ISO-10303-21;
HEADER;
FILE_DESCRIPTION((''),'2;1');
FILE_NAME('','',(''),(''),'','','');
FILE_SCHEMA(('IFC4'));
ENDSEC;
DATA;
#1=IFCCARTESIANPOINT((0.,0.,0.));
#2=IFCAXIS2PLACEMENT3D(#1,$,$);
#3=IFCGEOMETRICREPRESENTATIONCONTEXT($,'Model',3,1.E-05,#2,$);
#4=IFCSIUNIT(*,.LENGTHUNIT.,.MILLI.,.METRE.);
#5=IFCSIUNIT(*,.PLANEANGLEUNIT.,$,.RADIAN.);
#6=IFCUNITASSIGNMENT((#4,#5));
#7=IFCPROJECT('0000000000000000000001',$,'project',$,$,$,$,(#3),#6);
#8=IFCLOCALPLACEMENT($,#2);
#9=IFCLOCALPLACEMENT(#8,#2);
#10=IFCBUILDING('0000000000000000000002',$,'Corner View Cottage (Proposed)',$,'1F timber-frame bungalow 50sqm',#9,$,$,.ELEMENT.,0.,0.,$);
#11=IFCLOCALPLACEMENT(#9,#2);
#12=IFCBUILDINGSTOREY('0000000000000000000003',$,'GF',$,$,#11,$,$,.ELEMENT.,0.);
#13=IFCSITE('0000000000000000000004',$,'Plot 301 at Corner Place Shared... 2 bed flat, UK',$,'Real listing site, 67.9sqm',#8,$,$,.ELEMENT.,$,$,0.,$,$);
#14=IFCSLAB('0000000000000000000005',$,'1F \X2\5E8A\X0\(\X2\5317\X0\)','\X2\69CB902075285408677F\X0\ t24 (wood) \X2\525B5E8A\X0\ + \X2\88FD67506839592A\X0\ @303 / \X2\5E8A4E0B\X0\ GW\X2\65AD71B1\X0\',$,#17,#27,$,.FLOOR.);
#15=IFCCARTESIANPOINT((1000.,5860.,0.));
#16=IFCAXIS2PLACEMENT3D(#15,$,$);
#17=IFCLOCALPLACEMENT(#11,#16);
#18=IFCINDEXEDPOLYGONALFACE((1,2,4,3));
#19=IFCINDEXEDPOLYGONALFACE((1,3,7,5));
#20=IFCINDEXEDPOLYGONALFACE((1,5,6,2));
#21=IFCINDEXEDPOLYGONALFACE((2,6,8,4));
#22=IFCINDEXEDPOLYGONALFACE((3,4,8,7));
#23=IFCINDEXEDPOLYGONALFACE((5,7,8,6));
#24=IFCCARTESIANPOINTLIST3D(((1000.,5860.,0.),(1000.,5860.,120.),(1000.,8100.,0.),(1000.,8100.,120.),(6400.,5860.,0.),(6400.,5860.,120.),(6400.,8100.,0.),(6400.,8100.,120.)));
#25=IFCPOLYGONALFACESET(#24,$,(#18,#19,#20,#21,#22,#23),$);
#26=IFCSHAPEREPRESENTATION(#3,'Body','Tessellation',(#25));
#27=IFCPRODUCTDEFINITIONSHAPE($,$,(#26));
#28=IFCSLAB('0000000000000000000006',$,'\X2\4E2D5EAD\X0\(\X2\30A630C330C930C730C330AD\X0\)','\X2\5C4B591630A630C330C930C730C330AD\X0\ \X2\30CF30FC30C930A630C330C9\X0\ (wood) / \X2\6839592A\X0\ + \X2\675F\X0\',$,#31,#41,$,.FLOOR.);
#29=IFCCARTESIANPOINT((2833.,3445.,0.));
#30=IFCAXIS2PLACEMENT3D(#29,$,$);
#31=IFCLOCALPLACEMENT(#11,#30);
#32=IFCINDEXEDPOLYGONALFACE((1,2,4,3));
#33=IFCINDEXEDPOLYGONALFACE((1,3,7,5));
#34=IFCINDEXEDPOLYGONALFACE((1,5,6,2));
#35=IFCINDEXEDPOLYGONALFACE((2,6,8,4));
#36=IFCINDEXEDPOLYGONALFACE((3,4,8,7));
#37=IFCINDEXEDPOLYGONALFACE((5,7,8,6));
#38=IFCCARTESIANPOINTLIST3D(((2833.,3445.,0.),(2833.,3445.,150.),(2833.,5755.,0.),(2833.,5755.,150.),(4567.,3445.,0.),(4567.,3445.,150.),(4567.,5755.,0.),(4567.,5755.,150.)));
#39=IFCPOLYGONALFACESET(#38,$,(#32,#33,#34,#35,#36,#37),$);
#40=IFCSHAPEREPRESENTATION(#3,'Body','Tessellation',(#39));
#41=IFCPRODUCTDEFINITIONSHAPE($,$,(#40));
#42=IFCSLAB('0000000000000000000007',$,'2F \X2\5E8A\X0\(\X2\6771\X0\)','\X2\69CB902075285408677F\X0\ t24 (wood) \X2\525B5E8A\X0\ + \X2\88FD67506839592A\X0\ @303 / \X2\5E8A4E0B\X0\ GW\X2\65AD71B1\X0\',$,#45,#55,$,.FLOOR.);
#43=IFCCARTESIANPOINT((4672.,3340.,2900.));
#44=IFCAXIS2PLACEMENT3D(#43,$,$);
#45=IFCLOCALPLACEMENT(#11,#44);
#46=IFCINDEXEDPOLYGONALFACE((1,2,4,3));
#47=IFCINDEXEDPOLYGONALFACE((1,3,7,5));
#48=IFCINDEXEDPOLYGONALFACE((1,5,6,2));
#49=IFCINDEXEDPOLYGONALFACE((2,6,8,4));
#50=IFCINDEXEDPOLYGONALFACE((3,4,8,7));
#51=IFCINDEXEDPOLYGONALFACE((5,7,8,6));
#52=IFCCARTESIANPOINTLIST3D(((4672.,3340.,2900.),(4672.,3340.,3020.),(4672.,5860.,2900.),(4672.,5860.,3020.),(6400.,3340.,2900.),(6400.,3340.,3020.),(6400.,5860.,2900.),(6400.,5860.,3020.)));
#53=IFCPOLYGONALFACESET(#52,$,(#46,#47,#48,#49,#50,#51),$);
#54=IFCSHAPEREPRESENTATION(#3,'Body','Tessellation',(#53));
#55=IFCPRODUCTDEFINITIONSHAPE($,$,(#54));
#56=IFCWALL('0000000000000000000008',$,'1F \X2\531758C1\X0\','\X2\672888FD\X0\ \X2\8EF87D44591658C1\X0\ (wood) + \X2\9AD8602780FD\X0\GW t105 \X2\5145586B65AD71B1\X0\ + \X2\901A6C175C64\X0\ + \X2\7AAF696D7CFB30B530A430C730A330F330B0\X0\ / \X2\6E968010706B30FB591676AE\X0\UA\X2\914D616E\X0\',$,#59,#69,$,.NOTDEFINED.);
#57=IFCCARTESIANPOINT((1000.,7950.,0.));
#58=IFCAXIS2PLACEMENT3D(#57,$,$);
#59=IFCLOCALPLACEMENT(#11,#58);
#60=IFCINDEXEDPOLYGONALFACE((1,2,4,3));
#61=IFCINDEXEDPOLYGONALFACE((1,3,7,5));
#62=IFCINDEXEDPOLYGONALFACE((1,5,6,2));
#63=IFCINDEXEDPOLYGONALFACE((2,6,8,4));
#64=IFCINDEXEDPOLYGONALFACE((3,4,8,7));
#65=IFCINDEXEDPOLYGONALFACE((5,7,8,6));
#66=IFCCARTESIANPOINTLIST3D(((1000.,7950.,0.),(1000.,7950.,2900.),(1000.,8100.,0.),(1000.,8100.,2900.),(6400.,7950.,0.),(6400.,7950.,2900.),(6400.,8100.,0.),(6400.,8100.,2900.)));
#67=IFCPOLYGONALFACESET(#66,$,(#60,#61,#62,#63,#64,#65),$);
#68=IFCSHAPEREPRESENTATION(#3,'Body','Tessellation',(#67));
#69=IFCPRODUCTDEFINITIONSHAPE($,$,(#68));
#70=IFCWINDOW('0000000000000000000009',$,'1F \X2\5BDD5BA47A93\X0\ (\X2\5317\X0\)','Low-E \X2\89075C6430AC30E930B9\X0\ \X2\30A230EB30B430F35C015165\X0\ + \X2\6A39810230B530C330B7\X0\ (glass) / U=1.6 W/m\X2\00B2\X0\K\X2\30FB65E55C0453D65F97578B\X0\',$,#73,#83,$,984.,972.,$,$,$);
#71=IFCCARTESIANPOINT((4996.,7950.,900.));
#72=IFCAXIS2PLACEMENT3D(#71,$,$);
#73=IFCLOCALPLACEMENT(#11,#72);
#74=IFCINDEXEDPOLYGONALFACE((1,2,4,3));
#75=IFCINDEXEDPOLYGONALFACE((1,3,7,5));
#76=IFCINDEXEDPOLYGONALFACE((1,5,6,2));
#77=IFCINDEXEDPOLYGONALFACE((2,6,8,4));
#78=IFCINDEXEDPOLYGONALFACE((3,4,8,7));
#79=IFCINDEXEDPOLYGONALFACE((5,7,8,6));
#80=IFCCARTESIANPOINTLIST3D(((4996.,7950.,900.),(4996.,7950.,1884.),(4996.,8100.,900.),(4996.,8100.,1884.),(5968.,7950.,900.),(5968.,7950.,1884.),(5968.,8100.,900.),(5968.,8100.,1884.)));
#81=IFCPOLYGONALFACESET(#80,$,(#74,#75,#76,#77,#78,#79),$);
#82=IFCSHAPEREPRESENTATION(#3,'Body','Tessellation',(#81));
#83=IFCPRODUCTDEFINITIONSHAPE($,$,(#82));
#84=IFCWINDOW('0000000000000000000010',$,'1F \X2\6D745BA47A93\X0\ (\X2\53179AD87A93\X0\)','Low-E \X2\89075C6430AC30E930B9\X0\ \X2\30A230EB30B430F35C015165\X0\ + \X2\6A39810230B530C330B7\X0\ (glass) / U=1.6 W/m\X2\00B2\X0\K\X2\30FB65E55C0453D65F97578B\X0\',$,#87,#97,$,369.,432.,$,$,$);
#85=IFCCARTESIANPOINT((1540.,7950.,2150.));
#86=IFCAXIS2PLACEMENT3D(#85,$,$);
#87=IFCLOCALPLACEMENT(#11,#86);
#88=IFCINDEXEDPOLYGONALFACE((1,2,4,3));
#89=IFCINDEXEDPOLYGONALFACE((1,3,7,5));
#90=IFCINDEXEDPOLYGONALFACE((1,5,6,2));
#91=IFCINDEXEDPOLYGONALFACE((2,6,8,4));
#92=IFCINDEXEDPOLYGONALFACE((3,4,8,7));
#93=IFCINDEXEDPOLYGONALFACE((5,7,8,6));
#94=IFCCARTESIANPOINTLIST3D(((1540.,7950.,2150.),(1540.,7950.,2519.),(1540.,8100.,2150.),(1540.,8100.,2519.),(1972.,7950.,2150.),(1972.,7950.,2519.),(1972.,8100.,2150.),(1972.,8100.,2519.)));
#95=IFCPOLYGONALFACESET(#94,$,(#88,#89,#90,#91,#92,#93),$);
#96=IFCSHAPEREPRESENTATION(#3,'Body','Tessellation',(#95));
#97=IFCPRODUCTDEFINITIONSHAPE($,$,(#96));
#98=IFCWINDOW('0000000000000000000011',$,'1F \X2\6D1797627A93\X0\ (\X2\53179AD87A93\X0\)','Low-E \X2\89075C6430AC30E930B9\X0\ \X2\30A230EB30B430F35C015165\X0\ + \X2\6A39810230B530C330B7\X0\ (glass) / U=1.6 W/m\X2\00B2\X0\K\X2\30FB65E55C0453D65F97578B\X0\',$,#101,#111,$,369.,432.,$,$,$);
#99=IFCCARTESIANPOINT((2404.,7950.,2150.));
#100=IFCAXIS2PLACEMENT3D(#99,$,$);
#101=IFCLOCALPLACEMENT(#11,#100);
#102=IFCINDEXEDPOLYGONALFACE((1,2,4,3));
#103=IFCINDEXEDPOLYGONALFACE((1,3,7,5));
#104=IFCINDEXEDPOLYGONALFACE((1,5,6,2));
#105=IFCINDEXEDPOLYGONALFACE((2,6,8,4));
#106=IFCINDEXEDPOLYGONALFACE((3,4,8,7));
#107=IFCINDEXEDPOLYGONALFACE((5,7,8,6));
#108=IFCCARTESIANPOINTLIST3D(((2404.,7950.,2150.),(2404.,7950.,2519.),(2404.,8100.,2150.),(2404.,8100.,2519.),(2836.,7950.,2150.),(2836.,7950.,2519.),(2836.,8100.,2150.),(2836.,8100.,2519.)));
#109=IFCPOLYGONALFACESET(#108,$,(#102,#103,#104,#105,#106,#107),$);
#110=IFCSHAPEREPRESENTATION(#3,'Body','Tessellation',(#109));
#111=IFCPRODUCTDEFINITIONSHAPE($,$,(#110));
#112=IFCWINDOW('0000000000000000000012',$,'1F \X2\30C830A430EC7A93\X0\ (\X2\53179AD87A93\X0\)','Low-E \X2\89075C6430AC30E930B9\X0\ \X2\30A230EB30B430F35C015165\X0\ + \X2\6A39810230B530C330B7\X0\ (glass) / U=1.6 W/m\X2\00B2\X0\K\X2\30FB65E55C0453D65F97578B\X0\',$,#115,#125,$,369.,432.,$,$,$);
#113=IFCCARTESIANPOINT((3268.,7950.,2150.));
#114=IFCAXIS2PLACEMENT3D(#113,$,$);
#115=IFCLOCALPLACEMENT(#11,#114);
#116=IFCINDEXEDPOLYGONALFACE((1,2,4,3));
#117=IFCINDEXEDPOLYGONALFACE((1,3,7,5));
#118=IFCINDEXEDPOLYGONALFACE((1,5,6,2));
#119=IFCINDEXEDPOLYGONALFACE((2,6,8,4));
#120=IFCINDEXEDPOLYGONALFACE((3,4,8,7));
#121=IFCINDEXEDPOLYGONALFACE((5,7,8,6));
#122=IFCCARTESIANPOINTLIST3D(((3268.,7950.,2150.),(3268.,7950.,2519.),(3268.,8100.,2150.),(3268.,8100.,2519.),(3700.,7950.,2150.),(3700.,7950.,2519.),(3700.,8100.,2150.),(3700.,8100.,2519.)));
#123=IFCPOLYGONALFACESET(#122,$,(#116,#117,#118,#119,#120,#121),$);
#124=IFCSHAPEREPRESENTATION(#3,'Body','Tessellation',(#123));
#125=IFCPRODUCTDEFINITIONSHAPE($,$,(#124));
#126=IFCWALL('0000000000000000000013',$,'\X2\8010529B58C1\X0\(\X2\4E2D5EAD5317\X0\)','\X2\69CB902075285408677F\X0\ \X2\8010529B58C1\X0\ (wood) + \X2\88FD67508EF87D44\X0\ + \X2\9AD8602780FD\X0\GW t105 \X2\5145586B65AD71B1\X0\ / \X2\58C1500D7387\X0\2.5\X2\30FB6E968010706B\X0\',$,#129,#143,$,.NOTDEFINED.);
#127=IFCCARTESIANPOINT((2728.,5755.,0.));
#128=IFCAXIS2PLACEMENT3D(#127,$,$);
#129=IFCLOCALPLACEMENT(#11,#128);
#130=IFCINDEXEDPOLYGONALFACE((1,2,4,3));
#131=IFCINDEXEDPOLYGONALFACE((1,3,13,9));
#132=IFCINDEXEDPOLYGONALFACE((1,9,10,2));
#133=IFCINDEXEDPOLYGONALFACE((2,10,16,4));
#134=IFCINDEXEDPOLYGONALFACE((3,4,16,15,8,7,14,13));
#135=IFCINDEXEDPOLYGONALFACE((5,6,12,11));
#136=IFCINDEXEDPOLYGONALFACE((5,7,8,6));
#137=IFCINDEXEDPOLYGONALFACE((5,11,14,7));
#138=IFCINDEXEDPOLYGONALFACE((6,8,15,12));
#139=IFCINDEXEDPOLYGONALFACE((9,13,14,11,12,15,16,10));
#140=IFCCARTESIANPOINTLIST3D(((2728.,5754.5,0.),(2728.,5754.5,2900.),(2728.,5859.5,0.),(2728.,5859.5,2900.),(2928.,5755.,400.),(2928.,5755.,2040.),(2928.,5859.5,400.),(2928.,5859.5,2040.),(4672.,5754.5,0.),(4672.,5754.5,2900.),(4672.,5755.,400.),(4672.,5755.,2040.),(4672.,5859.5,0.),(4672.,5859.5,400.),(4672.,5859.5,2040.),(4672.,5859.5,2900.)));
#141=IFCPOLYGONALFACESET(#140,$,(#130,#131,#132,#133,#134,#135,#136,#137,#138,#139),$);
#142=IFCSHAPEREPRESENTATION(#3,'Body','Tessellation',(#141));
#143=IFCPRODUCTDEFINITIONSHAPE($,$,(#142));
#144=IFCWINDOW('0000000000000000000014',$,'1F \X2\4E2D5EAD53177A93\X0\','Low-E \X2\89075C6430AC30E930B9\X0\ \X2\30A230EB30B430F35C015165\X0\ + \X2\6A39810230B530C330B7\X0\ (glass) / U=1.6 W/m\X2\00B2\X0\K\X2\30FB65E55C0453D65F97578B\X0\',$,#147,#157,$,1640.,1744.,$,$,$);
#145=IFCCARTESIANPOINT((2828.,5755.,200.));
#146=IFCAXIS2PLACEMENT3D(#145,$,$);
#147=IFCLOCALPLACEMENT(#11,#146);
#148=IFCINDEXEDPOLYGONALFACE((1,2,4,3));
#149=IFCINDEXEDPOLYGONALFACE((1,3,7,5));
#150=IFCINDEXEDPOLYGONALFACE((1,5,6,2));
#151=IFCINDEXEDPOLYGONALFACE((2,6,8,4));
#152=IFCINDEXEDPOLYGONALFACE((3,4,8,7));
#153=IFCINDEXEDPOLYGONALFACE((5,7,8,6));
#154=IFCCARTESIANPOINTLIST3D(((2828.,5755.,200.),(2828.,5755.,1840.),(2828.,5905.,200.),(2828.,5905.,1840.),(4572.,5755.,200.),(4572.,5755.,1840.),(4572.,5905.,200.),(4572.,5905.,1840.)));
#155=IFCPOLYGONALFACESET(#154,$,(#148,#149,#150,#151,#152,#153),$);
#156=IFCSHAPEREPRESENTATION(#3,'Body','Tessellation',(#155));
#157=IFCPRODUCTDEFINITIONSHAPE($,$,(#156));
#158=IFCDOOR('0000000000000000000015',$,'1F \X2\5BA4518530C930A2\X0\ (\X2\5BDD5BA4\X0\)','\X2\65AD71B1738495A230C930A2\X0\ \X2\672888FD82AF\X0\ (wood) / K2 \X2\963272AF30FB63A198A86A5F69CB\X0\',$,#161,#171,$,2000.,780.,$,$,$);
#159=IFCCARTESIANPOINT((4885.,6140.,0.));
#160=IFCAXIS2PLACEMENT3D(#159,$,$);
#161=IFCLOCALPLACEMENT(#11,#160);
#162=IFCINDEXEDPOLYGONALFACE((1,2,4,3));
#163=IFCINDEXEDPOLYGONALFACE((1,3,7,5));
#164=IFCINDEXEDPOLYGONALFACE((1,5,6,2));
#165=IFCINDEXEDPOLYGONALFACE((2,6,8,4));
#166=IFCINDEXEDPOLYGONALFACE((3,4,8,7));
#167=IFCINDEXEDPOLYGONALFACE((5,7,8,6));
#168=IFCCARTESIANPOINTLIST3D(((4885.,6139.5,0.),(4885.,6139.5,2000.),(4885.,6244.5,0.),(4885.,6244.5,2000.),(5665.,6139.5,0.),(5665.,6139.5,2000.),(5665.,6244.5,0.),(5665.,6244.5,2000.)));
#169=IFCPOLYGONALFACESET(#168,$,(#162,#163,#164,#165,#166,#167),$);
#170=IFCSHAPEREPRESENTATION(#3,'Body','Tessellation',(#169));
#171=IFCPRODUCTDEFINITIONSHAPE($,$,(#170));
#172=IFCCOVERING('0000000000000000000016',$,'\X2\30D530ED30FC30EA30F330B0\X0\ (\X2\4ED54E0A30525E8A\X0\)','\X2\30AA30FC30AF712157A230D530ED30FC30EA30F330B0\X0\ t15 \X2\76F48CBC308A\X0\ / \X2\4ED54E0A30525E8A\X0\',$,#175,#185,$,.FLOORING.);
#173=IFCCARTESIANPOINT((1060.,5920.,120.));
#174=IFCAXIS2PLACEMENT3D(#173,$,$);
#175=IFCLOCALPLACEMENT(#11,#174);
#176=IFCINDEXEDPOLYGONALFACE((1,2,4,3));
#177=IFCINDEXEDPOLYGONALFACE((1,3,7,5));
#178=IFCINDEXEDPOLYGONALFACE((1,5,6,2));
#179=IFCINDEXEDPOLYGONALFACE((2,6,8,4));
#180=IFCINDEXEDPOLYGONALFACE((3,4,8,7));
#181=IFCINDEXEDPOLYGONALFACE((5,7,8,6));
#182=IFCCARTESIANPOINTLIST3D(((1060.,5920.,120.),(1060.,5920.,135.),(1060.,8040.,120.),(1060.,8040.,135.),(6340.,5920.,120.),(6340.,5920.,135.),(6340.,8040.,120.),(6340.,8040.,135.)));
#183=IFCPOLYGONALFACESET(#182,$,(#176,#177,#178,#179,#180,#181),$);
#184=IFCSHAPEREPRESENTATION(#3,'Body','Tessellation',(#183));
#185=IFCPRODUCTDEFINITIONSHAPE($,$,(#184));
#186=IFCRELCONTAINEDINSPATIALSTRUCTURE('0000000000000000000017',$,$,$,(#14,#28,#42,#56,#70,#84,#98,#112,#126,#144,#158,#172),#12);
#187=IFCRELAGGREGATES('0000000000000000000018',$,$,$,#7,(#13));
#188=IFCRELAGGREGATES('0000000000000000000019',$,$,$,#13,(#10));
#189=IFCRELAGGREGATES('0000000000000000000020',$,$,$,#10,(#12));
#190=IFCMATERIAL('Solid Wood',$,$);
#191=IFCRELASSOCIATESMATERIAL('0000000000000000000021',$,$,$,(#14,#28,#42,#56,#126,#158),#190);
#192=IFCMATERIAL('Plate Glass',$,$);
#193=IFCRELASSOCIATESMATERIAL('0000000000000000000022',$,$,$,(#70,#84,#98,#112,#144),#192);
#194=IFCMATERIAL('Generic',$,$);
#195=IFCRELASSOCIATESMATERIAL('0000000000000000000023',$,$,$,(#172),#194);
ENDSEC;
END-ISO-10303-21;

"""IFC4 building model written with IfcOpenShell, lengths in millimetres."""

from ifc_helpers import new_model, si_unit, frame, frame_2d, origin, place, context, project, spatial, rectangle, extrude, material, element, fill, save


model = new_model("IFC4")

# Units and contexts
model_context = context("Model", 3, precision=1e-05, world=origin())
ifc_project = project(units=[si_unit("LENGTHUNIT", "METRE", prefix="MILLI"), si_unit("PLANEANGLEUNIT", "RADIAN")], contexts=[model_context])

# Site, building, storey
site_placement = place(None, origin())
site = spatial("IfcSite", under=ifc_project, at=site_placement, Name="Plot 301 at Corner Place Shared... 2 bed flat, UK", ObjectType="Real listing site, 67.9sqm", CompositionType="ELEMENT", RefElevation=0.0)
building_placement = place(site_placement, origin())
building = spatial("IfcBuilding", under=site, at=building_placement, Name="Corner View Cottage (Proposed)", ObjectType="1F timber-frame bungalow 50sqm", CompositionType="ELEMENT", ElevationOfRefHeight=0.0, ElevationOfTerrain=0.0)
storey_placement = place(building_placement, origin())
storey = spatial("IfcBuildingStorey", under=building, at=storey_placement, Name="GF", CompositionType="ELEMENT", Elevation=0.0)

# Slabs
ifc_material_1 = material(Name="Solid Wood")
slab_1_placement = place(storey_placement, frame((1000.0, 5860.0, 0.0)))
element("IfcSlab", 1, at=slab_1_placement, inside=storey, material=ifc_material_1, Name="1F 床(北)", Description="構造用合板 t24 (wood) 剛床 + 製材根太 @303 / 床下 GW断熱", PredefinedType="FLOOR", context=model_context, shape_type="SweptSolid", body=[
    extrude(rectangle(XDim=5400.0, YDim=2240.0, at=frame_2d((2700.0, 1120.0))), frame((1000.0, 5860.0, 0.0)), (0.0, 0.0, 1.0), 120.0),
])
slab_2_placement = place(storey_placement, frame((2833.0, 3445.0, 0.0)))
element("IfcSlab", 2, at=slab_2_placement, inside=storey, material=ifc_material_1, Name="中庭(ウッドデッキ)", Description="屋外ウッドデッキ ハードウッド (wood) / 根太 + 束", PredefinedType="FLOOR", context=model_context, shape_type="SweptSolid", body=[
    extrude(rectangle(XDim=1734.0, YDim=2310.0, at=frame_2d((867.0, 1155.0))), frame((2833.0, 3445.0, 0.0)), (0.0, 0.0, 1.0), 150.0),
])
slab_3_placement = place(storey_placement, frame((4672.0, 3340.0, 2900.0)))
element("IfcSlab", 3, at=slab_3_placement, inside=storey, material=ifc_material_1, Name="2F 床(東)", Description="構造用合板 t24 (wood) 剛床 + 製材根太 @303 / 床下 GW断熱", PredefinedType="FLOOR", context=model_context, shape_type="SweptSolid", body=[
    extrude(rectangle(XDim=1728.0, YDim=2520.0, at=frame_2d((864.0, 1260.0))), frame((4672.0, 3340.0, 2900.0)), (0.0, 0.0, 1.0), 120.0),
])

# Wall, openings, windows
wall_1_placement = place(storey_placement, frame((1000.0, 7950.0, 0.0)))
wall_1 = element("IfcWall", 4, at=wall_1_placement, inside=storey, material=ifc_material_1, Name="1F 北壁", Description="木製 軸組外壁 (wood) + 高性能GW t105 充填断熱 + 通気層 + 窯業系サイディング / 準耐火・外皮UA配慮", PredefinedType="NOTDEFINED", context=model_context, shape_type="SweptSolid", body=[
    extrude(rectangle(XDim=5400.0, YDim=150.0, at=frame_2d((2700.0, 75.0))), frame((1000.0, 7950.0, 0.0)), (0.0, 0.0, 1.0), 2900.0),
])
opening_1_placement = place(storey_placement, frame((4996.0, 7950.0, 900.0)))
opening_1 = element("IfcOpeningElement", 5, at=opening_1_placement, cuts=wall_1, PredefinedType="NOTDEFINED", context=model_context, shape_type="SweptSolid", body=[
    extrude(rectangle(XDim=972.0, YDim=150.0, at=frame_2d((486.0, 75.0))), frame((4996.0, 7950.0, 900.0)), (0.0, 0.0, 1.0), 984.0),
])
opening_2_placement = place(storey_placement, frame((1540.0, 7950.0, 2150.0)))
opening_2 = element("IfcOpeningElement", 6, at=opening_2_placement, cuts=wall_1, PredefinedType="NOTDEFINED", context=model_context, shape_type="SweptSolid", body=[
    extrude(rectangle(XDim=432.0, YDim=150.0, at=frame_2d((216.0, 75.0))), frame((1540.0, 7950.0, 2150.0)), (0.0, 0.0, 1.0), 369.0),
])
opening_3_placement = place(storey_placement, frame((2404.0, 7950.0, 2150.0)))
opening_3 = element("IfcOpeningElement", 7, at=opening_3_placement, cuts=wall_1, PredefinedType="NOTDEFINED", context=model_context, shape_type="SweptSolid", body=[
    extrude(rectangle(XDim=432.0, YDim=150.0, at=frame_2d((216.0, 75.0))), frame((2404.0, 7950.0, 2150.0)), (0.0, 0.0, 1.0), 369.0),
])
opening_4_placement = place(storey_placement, frame((3268.0, 7950.0, 2150.0)))
opening_4 = element("IfcOpeningElement", 8, at=opening_4_placement, cuts=wall_1, PredefinedType="NOTDEFINED", context=model_context, shape_type="SweptSolid", body=[
    extrude(rectangle(XDim=432.0, YDim=150.0, at=frame_2d((216.0, 75.0))), frame((3268.0, 7950.0, 2150.0)), (0.0, 0.0, 1.0), 369.0),
])
ifc_material_2 = material(Name="Plate Glass")
window_1_placement = place(storey_placement, frame((4996.0, 7950.0, 900.0)))
window_1 = element("IfcWindow", 9, at=window_1_placement, inside=storey, material=ifc_material_2, Name="1F 寝室窓 (北)", Description="Low-E 複層ガラス アルゴン封入 + 樹脂サッシ (glass) / U=1.6 W/m²K・日射取得型", OverallHeight=984.0, OverallWidth=972.0, context=model_context, shape_type="SweptSolid", body=[
    extrude(rectangle(XDim=972.0, YDim=150.0, at=frame_2d((486.0, 75.0))), frame((4996.0, 7950.0, 900.0)), (0.0, 0.0, 1.0), 984.0),
])
fill(opening_1, window_1)
window_2_placement = place(storey_placement, frame((1540.0, 7950.0, 2150.0)))
window_2 = element("IfcWindow", 10, at=window_2_placement, inside=storey, material=ifc_material_2, Name="1F 浴室窓 (北高窓)", Description="Low-E 複層ガラス アルゴン封入 + 樹脂サッシ (glass) / U=1.6 W/m²K・日射取得型", OverallHeight=369.0, OverallWidth=432.0, context=model_context, shape_type="SweptSolid", body=[
    extrude(rectangle(XDim=432.0, YDim=150.0, at=frame_2d((216.0, 75.0))), frame((1540.0, 7950.0, 2150.0)), (0.0, 0.0, 1.0), 369.0),
])
fill(opening_2, window_2)
window_3_placement = place(storey_placement, frame((2404.0, 7950.0, 2150.0)))
window_3 = element("IfcWindow", 11, at=window_3_placement, inside=storey, material=ifc_material_2, Name="1F 洗面窓 (北高窓)", Description="Low-E 複層ガラス アルゴン封入 + 樹脂サッシ (glass) / U=1.6 W/m²K・日射取得型", OverallHeight=369.0, OverallWidth=432.0, context=model_context, shape_type="SweptSolid", body=[
    extrude(rectangle(XDim=432.0, YDim=150.0, at=frame_2d((216.0, 75.0))), frame((2404.0, 7950.0, 2150.0)), (0.0, 0.0, 1.0), 369.0),
])
fill(opening_3, window_3)
window_4_placement = place(storey_placement, frame((3268.0, 7950.0, 2150.0)))
window_4 = element("IfcWindow", 12, at=window_4_placement, inside=storey, material=ifc_material_2, Name="1F トイレ窓 (北高窓)", Description="Low-E 複層ガラス アルゴン封入 + 樹脂サッシ (glass) / U=1.6 W/m²K・日射取得型", OverallHeight=369.0, OverallWidth=432.0, context=model_context, shape_type="SweptSolid", body=[
    extrude(rectangle(XDim=432.0, YDim=150.0, at=frame_2d((216.0, 75.0))), frame((3268.0, 7950.0, 2150.0)), (0.0, 0.0, 1.0), 369.0),
])
fill(opening_4, window_4)

# Wall, opening, window
wall_2_placement = place(storey_placement, frame((2728.0, 5755.0, 0.0)))
wall_2 = element("IfcWall", 13, at=wall_2_placement, inside=storey, material=ifc_material_1, Name="耐力壁(中庭北)", Description="構造用合板 耐力壁 (wood) + 製材軸組 + 高性能GW t105 充填断熱 / 壁倍率2.5・準耐火", PredefinedType="NOTDEFINED", context=model_context, shape_type="SweptSolid", body=[
    extrude(rectangle(XDim=1944.0, YDim=105.0, at=frame_2d((972.0, 52.0))), frame((2728.0, 5755.0, 0.0)), (0.0, 0.0, 1.0), 2900.0),
])
opening_5_placement = place(storey_placement, frame((2828.0, 5755.0, 200.0)))
opening_5 = element("IfcOpeningElement", 14, at=opening_5_placement, cuts=wall_2, PredefinedType="NOTDEFINED", context=model_context, shape_type="SweptSolid", body=[
    extrude(rectangle(XDim=1744.0, YDim=150.0, at=frame_2d((872.0, 75.0))), frame((2828.0, 5755.0, 200.0)), (0.0, 0.0, 1.0), 1640.0),
])
window_5_placement = place(storey_placement, frame((2828.0, 5755.0, 200.0)))
window_5 = element("IfcWindow", 15, at=window_5_placement, inside=storey, material=ifc_material_2, Name="1F 中庭北窓", Description="Low-E 複層ガラス アルゴン封入 + 樹脂サッシ (glass) / U=1.6 W/m²K・日射取得型", OverallHeight=1640.0, OverallWidth=1744.0, context=model_context, shape_type="SweptSolid", body=[
    extrude(rectangle(XDim=1744.0, YDim=150.0, at=frame_2d((872.0, 75.0))), frame((2828.0, 5755.0, 200.0)), (0.0, 0.0, 1.0), 1640.0),
])
fill(opening_5, window_5)

# Door
door_1_placement = place(storey_placement, frame((4885.0, 6140.0, 0.0)))
element("IfcDoor", 16, at=door_1_placement, inside=storey, material=ifc_material_1, Name="1F 室内ドア (寝室)", Description="断熱玄関ドア 木製芯 (wood) / K2 防犯・採風機構", OverallHeight=2000.0, OverallWidth=780.0, context=model_context, shape_type="SweptSolid", body=[
    extrude(rectangle(XDim=780.0, YDim=105.0, at=frame_2d((390.0, 52.0))), frame((4885.0, 6140.0, 0.0)), (0.0, 0.0, 1.0), 2000.0),
])

# Covering
ifc_material_3 = material(Name="Generic")
covering_1_placement = place(storey_placement, frame((1060.0, 5920.0, 120.0)))
element("IfcCovering", 17, at=covering_1_placement, inside=storey, material=ifc_material_3, Name="フローリング (仕上げ床)", Description="オーク無垢フローリング t15 直貼り / 仕上げ床", PredefinedType="FLOORING", context=model_context, shape_type="SweptSolid", body=[
    extrude(rectangle(XDim=5280.0, YDim=2120.0, at=frame_2d((2640.0, 1060.0))), frame((1060.0, 5920.0, 120.0)), (0.0, 0.0, 1.0), 15.0),
])

save(model, "model.ifc")
